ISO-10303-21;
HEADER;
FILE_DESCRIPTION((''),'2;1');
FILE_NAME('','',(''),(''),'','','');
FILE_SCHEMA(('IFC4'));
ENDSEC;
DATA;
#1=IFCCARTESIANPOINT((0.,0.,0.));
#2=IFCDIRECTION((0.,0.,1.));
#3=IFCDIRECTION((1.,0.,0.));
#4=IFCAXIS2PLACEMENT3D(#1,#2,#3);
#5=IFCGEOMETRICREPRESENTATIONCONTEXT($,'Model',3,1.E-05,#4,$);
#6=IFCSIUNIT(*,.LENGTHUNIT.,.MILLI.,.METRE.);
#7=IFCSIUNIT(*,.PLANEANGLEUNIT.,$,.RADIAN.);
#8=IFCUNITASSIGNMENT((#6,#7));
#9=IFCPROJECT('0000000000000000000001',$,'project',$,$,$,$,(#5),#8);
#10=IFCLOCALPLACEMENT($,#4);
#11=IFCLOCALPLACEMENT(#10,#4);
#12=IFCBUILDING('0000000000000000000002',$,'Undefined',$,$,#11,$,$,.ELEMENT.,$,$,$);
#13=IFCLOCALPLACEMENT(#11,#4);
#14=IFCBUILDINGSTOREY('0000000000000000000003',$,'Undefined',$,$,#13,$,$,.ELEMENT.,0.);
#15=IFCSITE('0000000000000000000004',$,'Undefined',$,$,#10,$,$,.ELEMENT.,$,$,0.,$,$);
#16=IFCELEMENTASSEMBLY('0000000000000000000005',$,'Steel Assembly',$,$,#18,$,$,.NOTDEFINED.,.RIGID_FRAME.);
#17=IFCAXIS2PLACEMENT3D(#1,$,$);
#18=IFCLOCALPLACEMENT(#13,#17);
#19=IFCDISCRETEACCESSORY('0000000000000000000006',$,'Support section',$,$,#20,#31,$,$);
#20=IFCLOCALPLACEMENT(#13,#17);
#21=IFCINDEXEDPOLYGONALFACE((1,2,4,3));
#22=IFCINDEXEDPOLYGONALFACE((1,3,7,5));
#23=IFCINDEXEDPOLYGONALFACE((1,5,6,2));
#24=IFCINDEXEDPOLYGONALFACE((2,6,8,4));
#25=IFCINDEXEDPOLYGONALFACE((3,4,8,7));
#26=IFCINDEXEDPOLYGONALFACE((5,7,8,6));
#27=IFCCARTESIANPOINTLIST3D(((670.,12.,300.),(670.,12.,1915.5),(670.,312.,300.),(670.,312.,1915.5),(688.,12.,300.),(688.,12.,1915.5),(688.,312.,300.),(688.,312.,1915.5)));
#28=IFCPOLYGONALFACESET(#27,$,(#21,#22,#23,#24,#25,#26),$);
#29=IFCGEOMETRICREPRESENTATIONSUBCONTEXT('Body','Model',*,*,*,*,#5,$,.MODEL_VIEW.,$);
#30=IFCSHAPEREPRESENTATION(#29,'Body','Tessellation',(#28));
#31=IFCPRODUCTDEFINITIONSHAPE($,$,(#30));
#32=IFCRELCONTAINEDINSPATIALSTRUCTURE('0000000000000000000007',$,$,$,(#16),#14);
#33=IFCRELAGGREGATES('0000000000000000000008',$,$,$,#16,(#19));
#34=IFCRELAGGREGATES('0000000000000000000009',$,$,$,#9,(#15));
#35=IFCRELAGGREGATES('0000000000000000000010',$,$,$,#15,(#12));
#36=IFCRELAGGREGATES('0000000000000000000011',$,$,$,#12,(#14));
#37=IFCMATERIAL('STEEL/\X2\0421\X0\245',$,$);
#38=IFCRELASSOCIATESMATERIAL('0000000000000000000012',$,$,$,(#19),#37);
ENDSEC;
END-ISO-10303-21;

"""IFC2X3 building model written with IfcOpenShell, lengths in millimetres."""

from ifc_helpers import new_model, si_unit, frame, origin_with_axes, origin_2d_with_axis, place, context, subcontext, project, spatial, rectangle, extrude, material, element, aggregate, save


model = new_model("IFC2X3")

# Units and contexts
model_context = context("Model", 3, precision=1e-05, world=origin_with_axes())
body_context = subcontext(model_context, "Body", "Model", "MODEL_VIEW")
ifc_project = project(units=[si_unit("LENGTHUNIT", "METRE", prefix="MILLI"), si_unit("PLANEANGLEUNIT", "RADIAN")], contexts=[model_context])

# Site, building, storey
site_placement = place(None, origin_with_axes())
site = spatial("IfcSite", under=ifc_project, at=site_placement, Name="Undefined", CompositionType="ELEMENT", RefElevation=0.0)
building_placement = place(site_placement, origin_with_axes())
building = spatial("IfcBuilding", under=site, at=building_placement, Name="Undefined", CompositionType="ELEMENT")
storey_placement = place(building_placement, origin_with_axes())
storey = spatial("IfcBuildingStorey", under=building, at=storey_placement, Name="Undefined", CompositionType="ELEMENT", Elevation=0.0)

# Shared definitions
ifc_material_1 = material(Name="STEEL/С245")

# Element assembly
assembly_1_placement = place(storey_placement, origin_with_axes())
assembly_1 = element("IfcElementAssembly", 1, at=assembly_1_placement, inside=storey, Name="Steel Assembly", AssemblyPlace="NOTDEFINED", PredefinedType="RIGID_FRAME")

# Discrete accessory
discrete_accessory_1_placement = place(assembly_1_placement, frame((679.0, 162.0, 300.0), z_axis=(0.0, 0.0, 1.0), x_axis=(1.0, 0.0, 0.0)))
discrete_accessory_1 = element("IfcDiscreteAccessory", 2, at=discrete_accessory_1_placement, material=ifc_material_1, Name="Support section", context=body_context, shape_type="SweptSolid", body=[
    extrude(rectangle(XDim=18.0, YDim=300.0, at=origin_2d_with_axis()), frame((0.0, 0.0, 1615.5), z_axis=(0.0, 0.0, -1.0), x_axis=(1.0, 0.0, 0.0)), (0.0, 0.0, 1.0), 1615.5),
])
aggregate(assembly_1, [discrete_accessory_1])

save(model, "model.ifc")
